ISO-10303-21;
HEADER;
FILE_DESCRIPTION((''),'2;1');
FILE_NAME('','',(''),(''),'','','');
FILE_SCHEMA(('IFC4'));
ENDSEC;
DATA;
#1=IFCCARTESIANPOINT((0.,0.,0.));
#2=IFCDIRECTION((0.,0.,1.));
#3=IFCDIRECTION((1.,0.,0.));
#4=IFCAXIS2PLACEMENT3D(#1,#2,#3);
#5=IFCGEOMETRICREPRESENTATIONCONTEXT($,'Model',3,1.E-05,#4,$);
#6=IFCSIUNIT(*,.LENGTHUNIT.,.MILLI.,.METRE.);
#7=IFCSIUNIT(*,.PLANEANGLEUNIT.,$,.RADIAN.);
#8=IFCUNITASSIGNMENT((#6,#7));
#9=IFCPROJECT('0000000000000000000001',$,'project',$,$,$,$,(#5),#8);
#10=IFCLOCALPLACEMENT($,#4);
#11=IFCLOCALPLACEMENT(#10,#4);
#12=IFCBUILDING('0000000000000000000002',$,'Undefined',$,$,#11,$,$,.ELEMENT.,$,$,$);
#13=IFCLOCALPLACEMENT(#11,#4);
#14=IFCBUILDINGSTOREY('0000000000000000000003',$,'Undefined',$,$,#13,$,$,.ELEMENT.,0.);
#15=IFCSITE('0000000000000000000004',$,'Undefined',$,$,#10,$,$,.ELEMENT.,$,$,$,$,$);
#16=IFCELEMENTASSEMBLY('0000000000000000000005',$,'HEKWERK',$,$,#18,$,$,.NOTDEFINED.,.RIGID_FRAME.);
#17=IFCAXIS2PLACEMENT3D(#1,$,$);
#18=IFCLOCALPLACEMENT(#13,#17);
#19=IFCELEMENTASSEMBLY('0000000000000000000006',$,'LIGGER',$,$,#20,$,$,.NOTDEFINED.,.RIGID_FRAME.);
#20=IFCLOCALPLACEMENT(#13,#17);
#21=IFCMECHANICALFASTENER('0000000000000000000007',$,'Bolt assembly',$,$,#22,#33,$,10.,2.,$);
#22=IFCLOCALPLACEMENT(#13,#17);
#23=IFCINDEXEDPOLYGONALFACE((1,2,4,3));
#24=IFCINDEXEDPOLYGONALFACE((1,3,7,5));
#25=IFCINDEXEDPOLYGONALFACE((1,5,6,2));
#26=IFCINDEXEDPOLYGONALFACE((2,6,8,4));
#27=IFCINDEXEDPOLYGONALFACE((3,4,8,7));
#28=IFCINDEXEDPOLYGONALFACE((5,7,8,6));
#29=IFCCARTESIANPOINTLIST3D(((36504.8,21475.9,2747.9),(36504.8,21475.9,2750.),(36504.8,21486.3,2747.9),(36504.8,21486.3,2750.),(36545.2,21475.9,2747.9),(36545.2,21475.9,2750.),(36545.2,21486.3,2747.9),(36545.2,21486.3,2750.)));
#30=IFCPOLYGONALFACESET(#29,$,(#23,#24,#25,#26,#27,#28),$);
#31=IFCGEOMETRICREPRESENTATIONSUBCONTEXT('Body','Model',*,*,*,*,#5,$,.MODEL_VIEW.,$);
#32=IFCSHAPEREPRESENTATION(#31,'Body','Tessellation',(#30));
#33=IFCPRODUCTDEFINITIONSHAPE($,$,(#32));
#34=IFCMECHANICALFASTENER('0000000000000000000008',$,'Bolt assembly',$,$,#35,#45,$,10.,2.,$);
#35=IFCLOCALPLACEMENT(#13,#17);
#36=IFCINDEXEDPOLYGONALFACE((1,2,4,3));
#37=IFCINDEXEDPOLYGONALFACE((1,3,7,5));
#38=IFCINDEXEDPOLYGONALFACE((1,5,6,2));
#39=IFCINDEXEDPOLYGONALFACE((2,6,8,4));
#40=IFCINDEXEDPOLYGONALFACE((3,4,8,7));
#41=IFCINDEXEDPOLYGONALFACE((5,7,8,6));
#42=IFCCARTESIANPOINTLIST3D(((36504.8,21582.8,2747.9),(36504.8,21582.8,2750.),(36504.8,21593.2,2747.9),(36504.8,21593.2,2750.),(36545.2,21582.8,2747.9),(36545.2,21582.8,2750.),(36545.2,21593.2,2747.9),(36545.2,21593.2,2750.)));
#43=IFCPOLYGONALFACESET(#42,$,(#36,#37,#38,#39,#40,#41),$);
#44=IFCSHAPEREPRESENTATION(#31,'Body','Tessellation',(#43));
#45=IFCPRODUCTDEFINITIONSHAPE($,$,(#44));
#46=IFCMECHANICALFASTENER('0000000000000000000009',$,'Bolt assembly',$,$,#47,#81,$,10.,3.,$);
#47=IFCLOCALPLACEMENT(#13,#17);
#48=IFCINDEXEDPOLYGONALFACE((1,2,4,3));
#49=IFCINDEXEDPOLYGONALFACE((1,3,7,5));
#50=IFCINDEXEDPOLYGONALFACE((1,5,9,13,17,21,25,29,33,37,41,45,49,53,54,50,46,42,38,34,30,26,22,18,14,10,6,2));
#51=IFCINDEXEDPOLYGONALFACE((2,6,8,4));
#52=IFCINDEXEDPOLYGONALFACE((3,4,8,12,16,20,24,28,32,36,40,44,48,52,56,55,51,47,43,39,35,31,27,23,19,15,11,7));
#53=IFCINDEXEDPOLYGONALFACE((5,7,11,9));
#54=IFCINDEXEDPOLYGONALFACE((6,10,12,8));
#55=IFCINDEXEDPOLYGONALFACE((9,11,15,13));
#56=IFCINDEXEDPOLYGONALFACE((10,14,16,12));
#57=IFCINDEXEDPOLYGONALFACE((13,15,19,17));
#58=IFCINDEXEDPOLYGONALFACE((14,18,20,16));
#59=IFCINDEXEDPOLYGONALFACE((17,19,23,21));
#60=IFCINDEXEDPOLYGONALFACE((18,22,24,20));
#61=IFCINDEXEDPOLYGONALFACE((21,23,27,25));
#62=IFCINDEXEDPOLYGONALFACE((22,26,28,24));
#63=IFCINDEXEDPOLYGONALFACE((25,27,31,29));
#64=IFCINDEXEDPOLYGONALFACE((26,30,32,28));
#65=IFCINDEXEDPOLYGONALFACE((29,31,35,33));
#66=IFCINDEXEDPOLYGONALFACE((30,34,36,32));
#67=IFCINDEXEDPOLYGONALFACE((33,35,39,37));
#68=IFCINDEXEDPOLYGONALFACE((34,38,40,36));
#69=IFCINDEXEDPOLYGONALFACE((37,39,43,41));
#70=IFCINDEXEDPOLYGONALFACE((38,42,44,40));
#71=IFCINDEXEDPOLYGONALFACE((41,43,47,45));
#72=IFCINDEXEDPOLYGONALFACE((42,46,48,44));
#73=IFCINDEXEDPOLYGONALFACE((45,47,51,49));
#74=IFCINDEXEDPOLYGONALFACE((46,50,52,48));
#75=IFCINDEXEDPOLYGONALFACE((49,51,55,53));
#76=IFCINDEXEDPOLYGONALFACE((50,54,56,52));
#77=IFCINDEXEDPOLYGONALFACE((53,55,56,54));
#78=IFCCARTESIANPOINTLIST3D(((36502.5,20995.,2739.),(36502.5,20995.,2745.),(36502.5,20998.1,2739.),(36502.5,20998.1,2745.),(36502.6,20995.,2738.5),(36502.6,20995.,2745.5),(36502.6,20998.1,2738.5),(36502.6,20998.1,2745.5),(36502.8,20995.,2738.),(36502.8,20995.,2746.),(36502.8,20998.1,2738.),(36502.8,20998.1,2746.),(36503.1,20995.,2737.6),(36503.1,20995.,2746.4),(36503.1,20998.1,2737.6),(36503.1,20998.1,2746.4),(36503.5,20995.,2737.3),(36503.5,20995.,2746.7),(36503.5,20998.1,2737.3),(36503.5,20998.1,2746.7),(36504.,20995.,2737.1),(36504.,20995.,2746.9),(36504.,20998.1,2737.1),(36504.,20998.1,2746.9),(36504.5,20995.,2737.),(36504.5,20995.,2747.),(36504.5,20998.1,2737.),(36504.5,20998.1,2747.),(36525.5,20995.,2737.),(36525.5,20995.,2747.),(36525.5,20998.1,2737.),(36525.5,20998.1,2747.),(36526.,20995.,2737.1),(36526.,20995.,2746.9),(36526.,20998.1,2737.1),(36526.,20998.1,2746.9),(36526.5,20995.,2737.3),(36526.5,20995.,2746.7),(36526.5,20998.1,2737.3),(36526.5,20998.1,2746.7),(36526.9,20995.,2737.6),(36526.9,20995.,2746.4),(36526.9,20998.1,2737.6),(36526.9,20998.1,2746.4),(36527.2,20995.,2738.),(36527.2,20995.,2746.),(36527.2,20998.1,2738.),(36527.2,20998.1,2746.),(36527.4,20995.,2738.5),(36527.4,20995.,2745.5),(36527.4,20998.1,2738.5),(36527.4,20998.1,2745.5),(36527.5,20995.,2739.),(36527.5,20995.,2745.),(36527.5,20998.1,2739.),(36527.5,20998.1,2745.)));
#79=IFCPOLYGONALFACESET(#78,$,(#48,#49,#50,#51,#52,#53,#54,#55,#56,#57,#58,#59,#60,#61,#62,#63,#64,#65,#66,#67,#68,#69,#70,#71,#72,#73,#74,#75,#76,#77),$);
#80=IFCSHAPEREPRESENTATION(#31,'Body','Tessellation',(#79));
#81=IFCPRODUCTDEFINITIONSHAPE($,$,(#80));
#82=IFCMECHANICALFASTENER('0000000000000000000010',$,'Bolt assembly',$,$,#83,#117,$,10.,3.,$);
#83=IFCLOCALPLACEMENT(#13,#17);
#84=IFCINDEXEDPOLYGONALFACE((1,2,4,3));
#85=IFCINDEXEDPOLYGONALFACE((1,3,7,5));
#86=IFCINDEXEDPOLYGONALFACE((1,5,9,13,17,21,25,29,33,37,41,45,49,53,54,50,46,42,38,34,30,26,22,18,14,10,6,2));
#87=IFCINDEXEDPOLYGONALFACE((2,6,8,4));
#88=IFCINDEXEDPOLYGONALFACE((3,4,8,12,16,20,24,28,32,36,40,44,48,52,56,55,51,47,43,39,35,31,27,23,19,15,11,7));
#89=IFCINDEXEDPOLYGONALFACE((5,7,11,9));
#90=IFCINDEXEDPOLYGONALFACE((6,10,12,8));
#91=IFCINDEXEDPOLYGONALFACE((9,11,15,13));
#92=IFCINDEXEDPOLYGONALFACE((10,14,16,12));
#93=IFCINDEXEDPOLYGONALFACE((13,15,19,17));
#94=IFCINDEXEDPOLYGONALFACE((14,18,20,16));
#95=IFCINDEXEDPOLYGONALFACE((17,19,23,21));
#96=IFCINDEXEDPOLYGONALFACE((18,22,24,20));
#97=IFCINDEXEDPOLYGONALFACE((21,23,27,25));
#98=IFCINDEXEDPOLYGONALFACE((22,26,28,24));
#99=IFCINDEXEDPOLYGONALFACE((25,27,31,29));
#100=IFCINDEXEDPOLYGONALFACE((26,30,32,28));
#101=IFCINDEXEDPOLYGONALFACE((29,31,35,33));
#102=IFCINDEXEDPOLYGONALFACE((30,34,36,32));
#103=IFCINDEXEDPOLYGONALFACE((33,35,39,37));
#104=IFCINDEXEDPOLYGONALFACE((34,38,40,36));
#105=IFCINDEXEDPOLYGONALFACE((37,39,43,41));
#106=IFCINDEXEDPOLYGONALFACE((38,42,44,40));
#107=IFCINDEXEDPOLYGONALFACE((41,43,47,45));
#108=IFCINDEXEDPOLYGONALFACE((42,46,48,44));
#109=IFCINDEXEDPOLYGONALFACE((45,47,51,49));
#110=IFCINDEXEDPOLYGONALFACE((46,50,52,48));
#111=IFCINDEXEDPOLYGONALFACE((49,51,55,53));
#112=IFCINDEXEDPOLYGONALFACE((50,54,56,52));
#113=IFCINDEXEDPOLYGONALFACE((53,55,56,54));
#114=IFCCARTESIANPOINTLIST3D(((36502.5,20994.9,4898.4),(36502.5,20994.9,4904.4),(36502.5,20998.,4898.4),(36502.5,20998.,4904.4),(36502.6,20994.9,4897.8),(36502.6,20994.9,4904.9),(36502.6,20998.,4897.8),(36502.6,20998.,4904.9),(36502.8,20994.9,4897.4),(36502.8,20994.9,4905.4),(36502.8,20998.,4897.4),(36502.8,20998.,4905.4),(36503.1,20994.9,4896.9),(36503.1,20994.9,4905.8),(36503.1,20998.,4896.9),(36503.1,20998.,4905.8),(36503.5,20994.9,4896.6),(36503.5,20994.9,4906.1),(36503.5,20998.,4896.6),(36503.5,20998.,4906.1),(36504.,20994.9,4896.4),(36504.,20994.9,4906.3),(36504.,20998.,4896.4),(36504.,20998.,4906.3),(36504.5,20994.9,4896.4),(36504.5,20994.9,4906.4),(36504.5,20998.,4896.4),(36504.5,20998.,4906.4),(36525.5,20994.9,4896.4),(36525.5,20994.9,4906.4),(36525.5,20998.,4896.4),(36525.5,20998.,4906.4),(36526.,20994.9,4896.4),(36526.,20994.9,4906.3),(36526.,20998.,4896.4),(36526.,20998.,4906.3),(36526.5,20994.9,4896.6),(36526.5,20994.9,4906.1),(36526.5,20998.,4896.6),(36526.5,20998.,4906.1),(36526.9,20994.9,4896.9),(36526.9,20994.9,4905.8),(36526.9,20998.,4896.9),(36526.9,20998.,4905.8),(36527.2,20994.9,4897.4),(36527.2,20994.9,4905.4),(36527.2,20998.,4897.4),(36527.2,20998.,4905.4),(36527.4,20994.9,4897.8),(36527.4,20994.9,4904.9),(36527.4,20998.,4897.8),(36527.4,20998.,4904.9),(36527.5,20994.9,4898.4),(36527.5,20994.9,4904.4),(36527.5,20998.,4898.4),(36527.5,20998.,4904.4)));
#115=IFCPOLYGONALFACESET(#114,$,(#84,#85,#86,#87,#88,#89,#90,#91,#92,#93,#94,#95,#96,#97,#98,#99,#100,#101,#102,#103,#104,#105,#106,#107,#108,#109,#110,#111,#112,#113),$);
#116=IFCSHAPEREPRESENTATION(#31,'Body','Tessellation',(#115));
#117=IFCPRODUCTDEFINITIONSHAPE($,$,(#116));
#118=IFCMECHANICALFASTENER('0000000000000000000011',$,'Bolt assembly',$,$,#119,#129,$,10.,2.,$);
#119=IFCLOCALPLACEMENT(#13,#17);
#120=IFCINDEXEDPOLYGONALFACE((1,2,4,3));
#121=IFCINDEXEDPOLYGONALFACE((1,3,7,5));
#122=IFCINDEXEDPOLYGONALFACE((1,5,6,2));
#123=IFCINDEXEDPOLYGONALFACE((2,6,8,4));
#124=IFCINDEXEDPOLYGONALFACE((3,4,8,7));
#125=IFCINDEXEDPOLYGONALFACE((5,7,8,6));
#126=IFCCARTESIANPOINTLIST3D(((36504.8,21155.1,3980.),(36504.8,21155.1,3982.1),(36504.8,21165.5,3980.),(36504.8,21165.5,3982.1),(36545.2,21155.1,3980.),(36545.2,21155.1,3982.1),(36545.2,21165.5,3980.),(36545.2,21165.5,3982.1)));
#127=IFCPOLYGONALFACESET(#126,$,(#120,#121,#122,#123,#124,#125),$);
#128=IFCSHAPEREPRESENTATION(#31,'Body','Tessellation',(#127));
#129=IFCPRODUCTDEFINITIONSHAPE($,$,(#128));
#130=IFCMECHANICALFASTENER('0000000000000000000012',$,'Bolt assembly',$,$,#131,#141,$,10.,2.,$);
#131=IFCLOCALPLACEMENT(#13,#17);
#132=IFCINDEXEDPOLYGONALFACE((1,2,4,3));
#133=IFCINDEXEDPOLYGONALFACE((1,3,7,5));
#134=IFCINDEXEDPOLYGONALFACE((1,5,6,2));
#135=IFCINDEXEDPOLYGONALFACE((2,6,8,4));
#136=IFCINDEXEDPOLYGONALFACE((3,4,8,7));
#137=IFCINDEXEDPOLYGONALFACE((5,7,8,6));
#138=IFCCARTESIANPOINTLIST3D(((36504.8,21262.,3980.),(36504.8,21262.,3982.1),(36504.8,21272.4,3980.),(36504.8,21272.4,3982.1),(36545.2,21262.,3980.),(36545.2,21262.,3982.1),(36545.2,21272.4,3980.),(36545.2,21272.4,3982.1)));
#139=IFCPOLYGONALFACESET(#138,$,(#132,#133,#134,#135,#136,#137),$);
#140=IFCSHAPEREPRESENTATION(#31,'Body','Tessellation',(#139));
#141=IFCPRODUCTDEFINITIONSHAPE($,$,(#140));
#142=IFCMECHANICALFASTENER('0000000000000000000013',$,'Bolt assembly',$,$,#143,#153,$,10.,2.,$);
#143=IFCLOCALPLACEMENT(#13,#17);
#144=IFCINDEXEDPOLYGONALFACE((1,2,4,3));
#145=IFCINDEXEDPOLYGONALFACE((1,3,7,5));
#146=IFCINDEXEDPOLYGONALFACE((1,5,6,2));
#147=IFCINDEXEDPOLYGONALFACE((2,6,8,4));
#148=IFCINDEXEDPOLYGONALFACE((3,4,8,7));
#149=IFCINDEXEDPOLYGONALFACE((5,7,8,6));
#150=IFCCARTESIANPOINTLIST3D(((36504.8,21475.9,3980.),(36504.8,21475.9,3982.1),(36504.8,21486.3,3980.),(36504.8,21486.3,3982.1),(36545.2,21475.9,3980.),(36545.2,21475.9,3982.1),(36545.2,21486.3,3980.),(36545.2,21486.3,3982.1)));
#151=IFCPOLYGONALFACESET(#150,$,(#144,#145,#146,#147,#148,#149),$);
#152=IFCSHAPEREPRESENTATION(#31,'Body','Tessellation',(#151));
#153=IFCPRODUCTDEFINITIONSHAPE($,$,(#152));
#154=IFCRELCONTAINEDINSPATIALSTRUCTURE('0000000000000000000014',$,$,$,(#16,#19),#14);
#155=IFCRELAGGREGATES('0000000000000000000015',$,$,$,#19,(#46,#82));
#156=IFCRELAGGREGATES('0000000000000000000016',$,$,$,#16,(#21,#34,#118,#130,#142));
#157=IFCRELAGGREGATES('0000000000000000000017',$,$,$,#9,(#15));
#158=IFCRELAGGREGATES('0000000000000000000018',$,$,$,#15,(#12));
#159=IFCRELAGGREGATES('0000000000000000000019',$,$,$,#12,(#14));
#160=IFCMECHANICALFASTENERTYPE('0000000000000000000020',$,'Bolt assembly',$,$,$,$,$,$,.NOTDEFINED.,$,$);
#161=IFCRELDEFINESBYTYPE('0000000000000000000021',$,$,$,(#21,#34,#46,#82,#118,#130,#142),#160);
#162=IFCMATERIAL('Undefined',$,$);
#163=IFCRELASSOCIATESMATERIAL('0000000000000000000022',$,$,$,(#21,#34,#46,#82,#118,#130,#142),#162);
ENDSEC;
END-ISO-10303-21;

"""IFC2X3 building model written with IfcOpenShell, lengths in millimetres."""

from ifc_helpers import new_model, si_unit, frame, frame_2d, origin_with_axes, place, context, subcontext, project, spatial, polyline, circle_curve, parameter, trimmed, segment, composite_curve, outline, extrude, source, transform, mapped, material, type_object, element, aggregate, save


model = new_model("IFC2X3")

# Units and contexts
model_context = context("Model", 3, precision=1e-05, world=origin_with_axes())
body_context = subcontext(model_context, "Body", "Model", "MODEL_VIEW")
ifc_project = project(units=[si_unit("LENGTHUNIT", "METRE", prefix="MILLI"), si_unit("PLANEANGLEUNIT", "RADIAN")], contexts=[model_context])

# Site, building, storey
site_placement = place(None, origin_with_axes())
site = spatial("IfcSite", under=ifc_project, at=site_placement, Name="Undefined", CompositionType="ELEMENT")
building_placement = place(site_placement, origin_with_axes())
building = spatial("IfcBuilding", under=site, at=building_placement, Name="Undefined", CompositionType="ELEMENT")
storey_placement = place(building_placement, origin_with_axes())
storey = spatial("IfcBuildingStorey", under=building, at=storey_placement, Name="Undefined", CompositionType="ELEMENT", Elevation=0.0)

# Element assemblies
assembly_1_placement = place(storey_placement, origin_with_axes())
assembly_1 = element("IfcElementAssembly", 1, at=assembly_1_placement, inside=storey, Name="HEKWERK", AssemblyPlace="NOTDEFINED", PredefinedType="RIGID_FRAME")
assembly_2_placement = place(storey_placement, origin_with_axes())
assembly_2 = element("IfcElementAssembly", 2, at=assembly_2_placement, inside=storey, Name="LIGGER", AssemblyPlace="NOTDEFINED", PredefinedType="RIGID_FRAME")

# Shared definitions
ifc_material_1 = material(Name="Undefined")
mechanical_fastener_type = type_object("IfcMechanicalFastenerType", Name="Bolt assembly")

# Mechanical fasteners
shared_shape_1 = source(origin_with_axes(), body_context, "Body", "SweptSolid", [
    extrude(outline(composite_curve([segment(polyline([(-20.2, 5.2), (20.2, 5.2)]), True, "CONTINUOUS"), segment(polyline([(20.2, 5.2), (20.2, -5.2)]), True, "CONTINUOUS"), segment(polyline([(20.2, -5.2), (-20.2, -5.2)]), True, "CONTINUOUS"), segment(polyline([(-20.2, -5.2), (-20.2, 5.2)]), True, "CONTINUOUS")], self_intersect=False)), frame((0.0, -1.0, 0.0), z_axis=(0.0, 1.0, 0.0), x_axis=(1.0, 0.0, 0.0)), (0.0, 0.0, 1.0), 2.1),
])
mechanical_fastener_1_placement = place(assembly_1_placement, frame((36525.0, 21481.1, 2749.0), z_axis=(0.0, 1.0, 0.0), x_axis=(1.0, 0.0, 0.0)))
mechanical_fastener_1 = element("IfcMechanicalFastener", 3, at=mechanical_fastener_1_placement, type_object=mechanical_fastener_type, material=ifc_material_1, Name="Bolt assembly", NominalDiameter=10.0, NominalLength=2.0, context=body_context, shape_type="MappedRepresentation", body=[
    mapped(shared_shape_1, transform((0.0, 0.0, 0.0))),
])
shared_shape_2 = source(origin_with_axes(), body_context, "Body", "SweptSolid", [
    extrude(outline(composite_curve([segment(polyline([(-20.2, 5.2), (20.2, 5.2)]), True, "CONTINUOUS"), segment(polyline([(20.2, 5.2), (20.2, -5.2)]), True, "CONTINUOUS"), segment(polyline([(20.2, -5.2), (-20.2, -5.2)]), True, "CONTINUOUS"), segment(polyline([(-20.2, -5.2), (-20.2, 5.2)]), True, "CONTINUOUS")], self_intersect=False)), frame((0.0, -1.0, 0.0), z_axis=(0.0, 1.0, 0.0), x_axis=(1.0, 0.0, 0.0)), (0.0, 0.0, 1.0), 2.1),
])
mechanical_fastener_2_placement = place(assembly_1_placement, frame((36525.0, 21588.0, 2749.0), z_axis=(0.0, 1.0, 0.0), x_axis=(1.0, 0.0, 0.0)))
mechanical_fastener_2 = element("IfcMechanicalFastener", 4, at=mechanical_fastener_2_placement, type_object=mechanical_fastener_type, material=ifc_material_1, Name="Bolt assembly", NominalDiameter=10.0, NominalLength=2.0, context=body_context, shape_type="MappedRepresentation", body=[
    mapped(shared_shape_2, transform((0.0, 0.0, 0.0))),
])
shared_shape_3 = source(origin_with_axes(), body_context, "Body", "SweptSolid", [
    extrude(outline(composite_curve([segment(polyline([(-3.0, 12.5), (3.0, 12.5)]), True, "CONTINUOUS"), segment(trimmed(circle_curve(frame_2d((3.0, 10.5), x_axis=(0.0, 1.0)), 2.0), [parameter(0.0)], [parameter(4.712389)], False, "PARAMETER"), True, "CONTINUOUS"), segment(polyline([(5.0, 10.5), (5.0, -10.5)]), True, "CONTINUOUS"), segment(trimmed(circle_curve(frame_2d((3.0, -10.5), x_axis=(1.0, 0.0)), 2.0), [parameter(0.0)], [parameter(4.712389)], False, "PARAMETER"), True, "CONTINUOUS"), segment(polyline([(3.0, -12.5), (-3.0, -12.5)]), True, "CONTINUOUS"), segment(trimmed(circle_curve(frame_2d((-3.0, -10.5), x_axis=(0.0, -1.0)), 2.0), [parameter(0.0)], [parameter(4.712389)], False, "PARAMETER"), True, "CONTINUOUS"), segment(polyline([(-5.0, -10.5), (-5.0, 10.5)]), True, "CONTINUOUS"), segment(trimmed(circle_curve(frame_2d((-3.0, 10.5), x_axis=(-1.0, 0.0)), 2.0), [parameter(0.0)], [parameter(4.712389)], False, "PARAMETER"), True, "DISCONTINUOUS")], self_intersect=False)), frame((0.0, -3.0, 0.0), z_axis=(0.0, 1.0, 0.0), x_axis=(1.0, 0.0, 0.0)), (0.0, 0.0, 1.0), 3.1),
])
mechanical_fastener_3_placement = place(assembly_2_placement, frame((36515.0, 20998.0, 2742.0), z_axis=(-1.0, 0.0, 0.0), x_axis=(0.0, -0.000002, 1.0)))
mechanical_fastener_3 = element("IfcMechanicalFastener", 5, at=mechanical_fastener_3_placement, type_object=mechanical_fastener_type, material=ifc_material_1, Name="Bolt assembly", NominalDiameter=10.0, NominalLength=3.0, context=body_context, shape_type="MappedRepresentation", body=[
    mapped(shared_shape_3, transform((0.0, 0.0, 0.0))),
])
shared_shape_4 = source(origin_with_axes(), body_context, "Body", "SweptSolid", [
    extrude(outline(composite_curve([segment(polyline([(-3.0, 12.5), (3.0, 12.5)]), True, "CONTINUOUS"), segment(trimmed(circle_curve(frame_2d((3.0, 10.5), x_axis=(0.0, 1.0)), 2.0), [parameter(0.0)], [parameter(4.712389)], False, "PARAMETER"), True, "CONTINUOUS"), segment(polyline([(5.0, 10.5), (5.0, -10.5)]), True, "CONTINUOUS"), segment(trimmed(circle_curve(frame_2d((3.0, -10.5), x_axis=(1.0, 0.0)), 2.0), [parameter(0.0)], [parameter(4.712389)], False, "PARAMETER"), True, "CONTINUOUS"), segment(polyline([(3.0, -12.5), (-3.0, -12.5)]), True, "CONTINUOUS"), segment(trimmed(circle_curve(frame_2d((-3.0, -10.5), x_axis=(0.0, -1.0)), 2.0), [parameter(0.0)], [parameter(4.712389)], False, "PARAMETER"), True, "CONTINUOUS"), segment(polyline([(-5.0, -10.5), (-5.0, 10.5)]), True, "CONTINUOUS"), segment(trimmed(circle_curve(frame_2d((-3.0, 10.5), x_axis=(-1.0, 0.0)), 2.0), [parameter(0.0)], [parameter(4.712389)], False, "PARAMETER"), True, "DISCONTINUOUS")], self_intersect=False)), frame((0.0, 0.0, 0.0), z_axis=(0.0, 1.0, 0.0), x_axis=(1.0, 0.0, 0.0)), (0.0, 0.0, 1.0), 3.1),
])
mechanical_fastener_4_placement = place(assembly_2_placement, frame((36515.0, 20998.0, 4901.4), z_axis=(-1.0, 0.0, 0.0), x_axis=(0.0, 0.000002, -1.0)))
mechanical_fastener_4 = element("IfcMechanicalFastener", 6, at=mechanical_fastener_4_placement, type_object=mechanical_fastener_type, material=ifc_material_1, Name="Bolt assembly", NominalDiameter=10.0, NominalLength=3.0, context=body_context, shape_type="MappedRepresentation", body=[
    mapped(shared_shape_4, transform((0.0, 0.0, 0.0))),
])
shared_shape_5 = source(origin_with_axes(), body_context, "Body", "SweptSolid", [
    extrude(outline(composite_curve([segment(polyline([(-20.2, 5.2), (20.2, 5.2)]), True, "CONTINUOUS"), segment(polyline([(20.2, 5.2), (20.2, -5.2)]), True, "CONTINUOUS"), segment(polyline([(20.2, -5.2), (-20.2, -5.2)]), True, "CONTINUOUS"), segment(polyline([(-20.2, -5.2), (-20.2, 5.2)]), True, "CONTINUOUS")], self_intersect=False)), frame((0.0, -1.0, 0.0), z_axis=(0.0, 1.0, 0.0), x_axis=(1.0, 0.0, 0.0)), (0.0, 0.0, 1.0), 2.1),
])
mechanical_fastener_5_placement = place(assembly_1_placement, frame((36525.0, 21160.3, 3981.0), z_axis=(0.0, -1.0, 0.0), x_axis=(1.0, 0.0, 0.0)))
mechanical_fastener_5 = element("IfcMechanicalFastener", 7, at=mechanical_fastener_5_placement, type_object=mechanical_fastener_type, material=ifc_material_1, Name="Bolt assembly", NominalDiameter=10.0, NominalLength=2.0, context=body_context, shape_type="MappedRepresentation", body=[
    mapped(shared_shape_5, transform((0.0, 0.0, 0.0))),
])
shared_shape_6 = source(origin_with_axes(), body_context, "Body", "SweptSolid", [
    extrude(outline(composite_curve([segment(polyline([(-20.2, 5.2), (20.2, 5.2)]), True, "CONTINUOUS"), segment(polyline([(20.2, 5.2), (20.2, -5.2)]), True, "CONTINUOUS"), segment(polyline([(20.2, -5.2), (-20.2, -5.2)]), True, "CONTINUOUS"), segment(polyline([(-20.2, -5.2), (-20.2, 5.2)]), True, "CONTINUOUS")], self_intersect=False)), frame((0.0, -1.0, 0.0), z_axis=(0.0, 1.0, 0.0), x_axis=(1.0, 0.0, 0.0)), (0.0, 0.0, 1.0), 2.1),
])
mechanical_fastener_6_placement = place(assembly_1_placement, frame((36525.0, 21267.2, 3981.0), z_axis=(0.0, -1.0, 0.0), x_axis=(1.0, 0.0, 0.0)))
mechanical_fastener_6 = element("IfcMechanicalFastener", 8, at=mechanical_fastener_6_placement, type_object=mechanical_fastener_type, material=ifc_material_1, Name="Bolt assembly", NominalDiameter=10.0, NominalLength=2.0, context=body_context, shape_type="MappedRepresentation", body=[
    mapped(shared_shape_6, transform((0.0, 0.0, 0.0))),
])
shared_shape_7 = source(origin_with_axes(), body_context, "Body", "SweptSolid", [
    extrude(outline(composite_curve([segment(polyline([(-20.2, 5.2), (20.2, 5.2)]), True, "CONTINUOUS"), segment(polyline([(20.2, 5.2), (20.2, -5.2)]), True, "CONTINUOUS"), segment(polyline([(20.2, -5.2), (-20.2, -5.2)]), True, "CONTINUOUS"), segment(polyline([(-20.2, -5.2), (-20.2, 5.2)]), True, "CONTINUOUS")], self_intersect=False)), frame((0.0, -1.0, 0.0), z_axis=(0.0, 1.0, 0.0), x_axis=(1.0, 0.0, 0.0)), (0.0, 0.0, 1.0), 2.1),
])
mechanical_fastener_7_placement = place(assembly_1_placement, frame((36525.0, 21481.1, 3981.0), z_axis=(0.0, -1.0, 0.0), x_axis=(1.0, 0.0, 0.0)))
mechanical_fastener_7 = element("IfcMechanicalFastener", 9, at=mechanical_fastener_7_placement, type_object=mechanical_fastener_type, material=ifc_material_1, Name="Bolt assembly", NominalDiameter=10.0, NominalLength=2.0, context=body_context, shape_type="MappedRepresentation", body=[
    mapped(shared_shape_7, transform((0.0, 0.0, 0.0))),
])
aggregate(assembly_2, [mechanical_fastener_3, mechanical_fastener_4])
aggregate(assembly_1, [mechanical_fastener_1, mechanical_fastener_2, mechanical_fastener_5, mechanical_fastener_6, mechanical_fastener_7])

save(model, "model.ifc")
